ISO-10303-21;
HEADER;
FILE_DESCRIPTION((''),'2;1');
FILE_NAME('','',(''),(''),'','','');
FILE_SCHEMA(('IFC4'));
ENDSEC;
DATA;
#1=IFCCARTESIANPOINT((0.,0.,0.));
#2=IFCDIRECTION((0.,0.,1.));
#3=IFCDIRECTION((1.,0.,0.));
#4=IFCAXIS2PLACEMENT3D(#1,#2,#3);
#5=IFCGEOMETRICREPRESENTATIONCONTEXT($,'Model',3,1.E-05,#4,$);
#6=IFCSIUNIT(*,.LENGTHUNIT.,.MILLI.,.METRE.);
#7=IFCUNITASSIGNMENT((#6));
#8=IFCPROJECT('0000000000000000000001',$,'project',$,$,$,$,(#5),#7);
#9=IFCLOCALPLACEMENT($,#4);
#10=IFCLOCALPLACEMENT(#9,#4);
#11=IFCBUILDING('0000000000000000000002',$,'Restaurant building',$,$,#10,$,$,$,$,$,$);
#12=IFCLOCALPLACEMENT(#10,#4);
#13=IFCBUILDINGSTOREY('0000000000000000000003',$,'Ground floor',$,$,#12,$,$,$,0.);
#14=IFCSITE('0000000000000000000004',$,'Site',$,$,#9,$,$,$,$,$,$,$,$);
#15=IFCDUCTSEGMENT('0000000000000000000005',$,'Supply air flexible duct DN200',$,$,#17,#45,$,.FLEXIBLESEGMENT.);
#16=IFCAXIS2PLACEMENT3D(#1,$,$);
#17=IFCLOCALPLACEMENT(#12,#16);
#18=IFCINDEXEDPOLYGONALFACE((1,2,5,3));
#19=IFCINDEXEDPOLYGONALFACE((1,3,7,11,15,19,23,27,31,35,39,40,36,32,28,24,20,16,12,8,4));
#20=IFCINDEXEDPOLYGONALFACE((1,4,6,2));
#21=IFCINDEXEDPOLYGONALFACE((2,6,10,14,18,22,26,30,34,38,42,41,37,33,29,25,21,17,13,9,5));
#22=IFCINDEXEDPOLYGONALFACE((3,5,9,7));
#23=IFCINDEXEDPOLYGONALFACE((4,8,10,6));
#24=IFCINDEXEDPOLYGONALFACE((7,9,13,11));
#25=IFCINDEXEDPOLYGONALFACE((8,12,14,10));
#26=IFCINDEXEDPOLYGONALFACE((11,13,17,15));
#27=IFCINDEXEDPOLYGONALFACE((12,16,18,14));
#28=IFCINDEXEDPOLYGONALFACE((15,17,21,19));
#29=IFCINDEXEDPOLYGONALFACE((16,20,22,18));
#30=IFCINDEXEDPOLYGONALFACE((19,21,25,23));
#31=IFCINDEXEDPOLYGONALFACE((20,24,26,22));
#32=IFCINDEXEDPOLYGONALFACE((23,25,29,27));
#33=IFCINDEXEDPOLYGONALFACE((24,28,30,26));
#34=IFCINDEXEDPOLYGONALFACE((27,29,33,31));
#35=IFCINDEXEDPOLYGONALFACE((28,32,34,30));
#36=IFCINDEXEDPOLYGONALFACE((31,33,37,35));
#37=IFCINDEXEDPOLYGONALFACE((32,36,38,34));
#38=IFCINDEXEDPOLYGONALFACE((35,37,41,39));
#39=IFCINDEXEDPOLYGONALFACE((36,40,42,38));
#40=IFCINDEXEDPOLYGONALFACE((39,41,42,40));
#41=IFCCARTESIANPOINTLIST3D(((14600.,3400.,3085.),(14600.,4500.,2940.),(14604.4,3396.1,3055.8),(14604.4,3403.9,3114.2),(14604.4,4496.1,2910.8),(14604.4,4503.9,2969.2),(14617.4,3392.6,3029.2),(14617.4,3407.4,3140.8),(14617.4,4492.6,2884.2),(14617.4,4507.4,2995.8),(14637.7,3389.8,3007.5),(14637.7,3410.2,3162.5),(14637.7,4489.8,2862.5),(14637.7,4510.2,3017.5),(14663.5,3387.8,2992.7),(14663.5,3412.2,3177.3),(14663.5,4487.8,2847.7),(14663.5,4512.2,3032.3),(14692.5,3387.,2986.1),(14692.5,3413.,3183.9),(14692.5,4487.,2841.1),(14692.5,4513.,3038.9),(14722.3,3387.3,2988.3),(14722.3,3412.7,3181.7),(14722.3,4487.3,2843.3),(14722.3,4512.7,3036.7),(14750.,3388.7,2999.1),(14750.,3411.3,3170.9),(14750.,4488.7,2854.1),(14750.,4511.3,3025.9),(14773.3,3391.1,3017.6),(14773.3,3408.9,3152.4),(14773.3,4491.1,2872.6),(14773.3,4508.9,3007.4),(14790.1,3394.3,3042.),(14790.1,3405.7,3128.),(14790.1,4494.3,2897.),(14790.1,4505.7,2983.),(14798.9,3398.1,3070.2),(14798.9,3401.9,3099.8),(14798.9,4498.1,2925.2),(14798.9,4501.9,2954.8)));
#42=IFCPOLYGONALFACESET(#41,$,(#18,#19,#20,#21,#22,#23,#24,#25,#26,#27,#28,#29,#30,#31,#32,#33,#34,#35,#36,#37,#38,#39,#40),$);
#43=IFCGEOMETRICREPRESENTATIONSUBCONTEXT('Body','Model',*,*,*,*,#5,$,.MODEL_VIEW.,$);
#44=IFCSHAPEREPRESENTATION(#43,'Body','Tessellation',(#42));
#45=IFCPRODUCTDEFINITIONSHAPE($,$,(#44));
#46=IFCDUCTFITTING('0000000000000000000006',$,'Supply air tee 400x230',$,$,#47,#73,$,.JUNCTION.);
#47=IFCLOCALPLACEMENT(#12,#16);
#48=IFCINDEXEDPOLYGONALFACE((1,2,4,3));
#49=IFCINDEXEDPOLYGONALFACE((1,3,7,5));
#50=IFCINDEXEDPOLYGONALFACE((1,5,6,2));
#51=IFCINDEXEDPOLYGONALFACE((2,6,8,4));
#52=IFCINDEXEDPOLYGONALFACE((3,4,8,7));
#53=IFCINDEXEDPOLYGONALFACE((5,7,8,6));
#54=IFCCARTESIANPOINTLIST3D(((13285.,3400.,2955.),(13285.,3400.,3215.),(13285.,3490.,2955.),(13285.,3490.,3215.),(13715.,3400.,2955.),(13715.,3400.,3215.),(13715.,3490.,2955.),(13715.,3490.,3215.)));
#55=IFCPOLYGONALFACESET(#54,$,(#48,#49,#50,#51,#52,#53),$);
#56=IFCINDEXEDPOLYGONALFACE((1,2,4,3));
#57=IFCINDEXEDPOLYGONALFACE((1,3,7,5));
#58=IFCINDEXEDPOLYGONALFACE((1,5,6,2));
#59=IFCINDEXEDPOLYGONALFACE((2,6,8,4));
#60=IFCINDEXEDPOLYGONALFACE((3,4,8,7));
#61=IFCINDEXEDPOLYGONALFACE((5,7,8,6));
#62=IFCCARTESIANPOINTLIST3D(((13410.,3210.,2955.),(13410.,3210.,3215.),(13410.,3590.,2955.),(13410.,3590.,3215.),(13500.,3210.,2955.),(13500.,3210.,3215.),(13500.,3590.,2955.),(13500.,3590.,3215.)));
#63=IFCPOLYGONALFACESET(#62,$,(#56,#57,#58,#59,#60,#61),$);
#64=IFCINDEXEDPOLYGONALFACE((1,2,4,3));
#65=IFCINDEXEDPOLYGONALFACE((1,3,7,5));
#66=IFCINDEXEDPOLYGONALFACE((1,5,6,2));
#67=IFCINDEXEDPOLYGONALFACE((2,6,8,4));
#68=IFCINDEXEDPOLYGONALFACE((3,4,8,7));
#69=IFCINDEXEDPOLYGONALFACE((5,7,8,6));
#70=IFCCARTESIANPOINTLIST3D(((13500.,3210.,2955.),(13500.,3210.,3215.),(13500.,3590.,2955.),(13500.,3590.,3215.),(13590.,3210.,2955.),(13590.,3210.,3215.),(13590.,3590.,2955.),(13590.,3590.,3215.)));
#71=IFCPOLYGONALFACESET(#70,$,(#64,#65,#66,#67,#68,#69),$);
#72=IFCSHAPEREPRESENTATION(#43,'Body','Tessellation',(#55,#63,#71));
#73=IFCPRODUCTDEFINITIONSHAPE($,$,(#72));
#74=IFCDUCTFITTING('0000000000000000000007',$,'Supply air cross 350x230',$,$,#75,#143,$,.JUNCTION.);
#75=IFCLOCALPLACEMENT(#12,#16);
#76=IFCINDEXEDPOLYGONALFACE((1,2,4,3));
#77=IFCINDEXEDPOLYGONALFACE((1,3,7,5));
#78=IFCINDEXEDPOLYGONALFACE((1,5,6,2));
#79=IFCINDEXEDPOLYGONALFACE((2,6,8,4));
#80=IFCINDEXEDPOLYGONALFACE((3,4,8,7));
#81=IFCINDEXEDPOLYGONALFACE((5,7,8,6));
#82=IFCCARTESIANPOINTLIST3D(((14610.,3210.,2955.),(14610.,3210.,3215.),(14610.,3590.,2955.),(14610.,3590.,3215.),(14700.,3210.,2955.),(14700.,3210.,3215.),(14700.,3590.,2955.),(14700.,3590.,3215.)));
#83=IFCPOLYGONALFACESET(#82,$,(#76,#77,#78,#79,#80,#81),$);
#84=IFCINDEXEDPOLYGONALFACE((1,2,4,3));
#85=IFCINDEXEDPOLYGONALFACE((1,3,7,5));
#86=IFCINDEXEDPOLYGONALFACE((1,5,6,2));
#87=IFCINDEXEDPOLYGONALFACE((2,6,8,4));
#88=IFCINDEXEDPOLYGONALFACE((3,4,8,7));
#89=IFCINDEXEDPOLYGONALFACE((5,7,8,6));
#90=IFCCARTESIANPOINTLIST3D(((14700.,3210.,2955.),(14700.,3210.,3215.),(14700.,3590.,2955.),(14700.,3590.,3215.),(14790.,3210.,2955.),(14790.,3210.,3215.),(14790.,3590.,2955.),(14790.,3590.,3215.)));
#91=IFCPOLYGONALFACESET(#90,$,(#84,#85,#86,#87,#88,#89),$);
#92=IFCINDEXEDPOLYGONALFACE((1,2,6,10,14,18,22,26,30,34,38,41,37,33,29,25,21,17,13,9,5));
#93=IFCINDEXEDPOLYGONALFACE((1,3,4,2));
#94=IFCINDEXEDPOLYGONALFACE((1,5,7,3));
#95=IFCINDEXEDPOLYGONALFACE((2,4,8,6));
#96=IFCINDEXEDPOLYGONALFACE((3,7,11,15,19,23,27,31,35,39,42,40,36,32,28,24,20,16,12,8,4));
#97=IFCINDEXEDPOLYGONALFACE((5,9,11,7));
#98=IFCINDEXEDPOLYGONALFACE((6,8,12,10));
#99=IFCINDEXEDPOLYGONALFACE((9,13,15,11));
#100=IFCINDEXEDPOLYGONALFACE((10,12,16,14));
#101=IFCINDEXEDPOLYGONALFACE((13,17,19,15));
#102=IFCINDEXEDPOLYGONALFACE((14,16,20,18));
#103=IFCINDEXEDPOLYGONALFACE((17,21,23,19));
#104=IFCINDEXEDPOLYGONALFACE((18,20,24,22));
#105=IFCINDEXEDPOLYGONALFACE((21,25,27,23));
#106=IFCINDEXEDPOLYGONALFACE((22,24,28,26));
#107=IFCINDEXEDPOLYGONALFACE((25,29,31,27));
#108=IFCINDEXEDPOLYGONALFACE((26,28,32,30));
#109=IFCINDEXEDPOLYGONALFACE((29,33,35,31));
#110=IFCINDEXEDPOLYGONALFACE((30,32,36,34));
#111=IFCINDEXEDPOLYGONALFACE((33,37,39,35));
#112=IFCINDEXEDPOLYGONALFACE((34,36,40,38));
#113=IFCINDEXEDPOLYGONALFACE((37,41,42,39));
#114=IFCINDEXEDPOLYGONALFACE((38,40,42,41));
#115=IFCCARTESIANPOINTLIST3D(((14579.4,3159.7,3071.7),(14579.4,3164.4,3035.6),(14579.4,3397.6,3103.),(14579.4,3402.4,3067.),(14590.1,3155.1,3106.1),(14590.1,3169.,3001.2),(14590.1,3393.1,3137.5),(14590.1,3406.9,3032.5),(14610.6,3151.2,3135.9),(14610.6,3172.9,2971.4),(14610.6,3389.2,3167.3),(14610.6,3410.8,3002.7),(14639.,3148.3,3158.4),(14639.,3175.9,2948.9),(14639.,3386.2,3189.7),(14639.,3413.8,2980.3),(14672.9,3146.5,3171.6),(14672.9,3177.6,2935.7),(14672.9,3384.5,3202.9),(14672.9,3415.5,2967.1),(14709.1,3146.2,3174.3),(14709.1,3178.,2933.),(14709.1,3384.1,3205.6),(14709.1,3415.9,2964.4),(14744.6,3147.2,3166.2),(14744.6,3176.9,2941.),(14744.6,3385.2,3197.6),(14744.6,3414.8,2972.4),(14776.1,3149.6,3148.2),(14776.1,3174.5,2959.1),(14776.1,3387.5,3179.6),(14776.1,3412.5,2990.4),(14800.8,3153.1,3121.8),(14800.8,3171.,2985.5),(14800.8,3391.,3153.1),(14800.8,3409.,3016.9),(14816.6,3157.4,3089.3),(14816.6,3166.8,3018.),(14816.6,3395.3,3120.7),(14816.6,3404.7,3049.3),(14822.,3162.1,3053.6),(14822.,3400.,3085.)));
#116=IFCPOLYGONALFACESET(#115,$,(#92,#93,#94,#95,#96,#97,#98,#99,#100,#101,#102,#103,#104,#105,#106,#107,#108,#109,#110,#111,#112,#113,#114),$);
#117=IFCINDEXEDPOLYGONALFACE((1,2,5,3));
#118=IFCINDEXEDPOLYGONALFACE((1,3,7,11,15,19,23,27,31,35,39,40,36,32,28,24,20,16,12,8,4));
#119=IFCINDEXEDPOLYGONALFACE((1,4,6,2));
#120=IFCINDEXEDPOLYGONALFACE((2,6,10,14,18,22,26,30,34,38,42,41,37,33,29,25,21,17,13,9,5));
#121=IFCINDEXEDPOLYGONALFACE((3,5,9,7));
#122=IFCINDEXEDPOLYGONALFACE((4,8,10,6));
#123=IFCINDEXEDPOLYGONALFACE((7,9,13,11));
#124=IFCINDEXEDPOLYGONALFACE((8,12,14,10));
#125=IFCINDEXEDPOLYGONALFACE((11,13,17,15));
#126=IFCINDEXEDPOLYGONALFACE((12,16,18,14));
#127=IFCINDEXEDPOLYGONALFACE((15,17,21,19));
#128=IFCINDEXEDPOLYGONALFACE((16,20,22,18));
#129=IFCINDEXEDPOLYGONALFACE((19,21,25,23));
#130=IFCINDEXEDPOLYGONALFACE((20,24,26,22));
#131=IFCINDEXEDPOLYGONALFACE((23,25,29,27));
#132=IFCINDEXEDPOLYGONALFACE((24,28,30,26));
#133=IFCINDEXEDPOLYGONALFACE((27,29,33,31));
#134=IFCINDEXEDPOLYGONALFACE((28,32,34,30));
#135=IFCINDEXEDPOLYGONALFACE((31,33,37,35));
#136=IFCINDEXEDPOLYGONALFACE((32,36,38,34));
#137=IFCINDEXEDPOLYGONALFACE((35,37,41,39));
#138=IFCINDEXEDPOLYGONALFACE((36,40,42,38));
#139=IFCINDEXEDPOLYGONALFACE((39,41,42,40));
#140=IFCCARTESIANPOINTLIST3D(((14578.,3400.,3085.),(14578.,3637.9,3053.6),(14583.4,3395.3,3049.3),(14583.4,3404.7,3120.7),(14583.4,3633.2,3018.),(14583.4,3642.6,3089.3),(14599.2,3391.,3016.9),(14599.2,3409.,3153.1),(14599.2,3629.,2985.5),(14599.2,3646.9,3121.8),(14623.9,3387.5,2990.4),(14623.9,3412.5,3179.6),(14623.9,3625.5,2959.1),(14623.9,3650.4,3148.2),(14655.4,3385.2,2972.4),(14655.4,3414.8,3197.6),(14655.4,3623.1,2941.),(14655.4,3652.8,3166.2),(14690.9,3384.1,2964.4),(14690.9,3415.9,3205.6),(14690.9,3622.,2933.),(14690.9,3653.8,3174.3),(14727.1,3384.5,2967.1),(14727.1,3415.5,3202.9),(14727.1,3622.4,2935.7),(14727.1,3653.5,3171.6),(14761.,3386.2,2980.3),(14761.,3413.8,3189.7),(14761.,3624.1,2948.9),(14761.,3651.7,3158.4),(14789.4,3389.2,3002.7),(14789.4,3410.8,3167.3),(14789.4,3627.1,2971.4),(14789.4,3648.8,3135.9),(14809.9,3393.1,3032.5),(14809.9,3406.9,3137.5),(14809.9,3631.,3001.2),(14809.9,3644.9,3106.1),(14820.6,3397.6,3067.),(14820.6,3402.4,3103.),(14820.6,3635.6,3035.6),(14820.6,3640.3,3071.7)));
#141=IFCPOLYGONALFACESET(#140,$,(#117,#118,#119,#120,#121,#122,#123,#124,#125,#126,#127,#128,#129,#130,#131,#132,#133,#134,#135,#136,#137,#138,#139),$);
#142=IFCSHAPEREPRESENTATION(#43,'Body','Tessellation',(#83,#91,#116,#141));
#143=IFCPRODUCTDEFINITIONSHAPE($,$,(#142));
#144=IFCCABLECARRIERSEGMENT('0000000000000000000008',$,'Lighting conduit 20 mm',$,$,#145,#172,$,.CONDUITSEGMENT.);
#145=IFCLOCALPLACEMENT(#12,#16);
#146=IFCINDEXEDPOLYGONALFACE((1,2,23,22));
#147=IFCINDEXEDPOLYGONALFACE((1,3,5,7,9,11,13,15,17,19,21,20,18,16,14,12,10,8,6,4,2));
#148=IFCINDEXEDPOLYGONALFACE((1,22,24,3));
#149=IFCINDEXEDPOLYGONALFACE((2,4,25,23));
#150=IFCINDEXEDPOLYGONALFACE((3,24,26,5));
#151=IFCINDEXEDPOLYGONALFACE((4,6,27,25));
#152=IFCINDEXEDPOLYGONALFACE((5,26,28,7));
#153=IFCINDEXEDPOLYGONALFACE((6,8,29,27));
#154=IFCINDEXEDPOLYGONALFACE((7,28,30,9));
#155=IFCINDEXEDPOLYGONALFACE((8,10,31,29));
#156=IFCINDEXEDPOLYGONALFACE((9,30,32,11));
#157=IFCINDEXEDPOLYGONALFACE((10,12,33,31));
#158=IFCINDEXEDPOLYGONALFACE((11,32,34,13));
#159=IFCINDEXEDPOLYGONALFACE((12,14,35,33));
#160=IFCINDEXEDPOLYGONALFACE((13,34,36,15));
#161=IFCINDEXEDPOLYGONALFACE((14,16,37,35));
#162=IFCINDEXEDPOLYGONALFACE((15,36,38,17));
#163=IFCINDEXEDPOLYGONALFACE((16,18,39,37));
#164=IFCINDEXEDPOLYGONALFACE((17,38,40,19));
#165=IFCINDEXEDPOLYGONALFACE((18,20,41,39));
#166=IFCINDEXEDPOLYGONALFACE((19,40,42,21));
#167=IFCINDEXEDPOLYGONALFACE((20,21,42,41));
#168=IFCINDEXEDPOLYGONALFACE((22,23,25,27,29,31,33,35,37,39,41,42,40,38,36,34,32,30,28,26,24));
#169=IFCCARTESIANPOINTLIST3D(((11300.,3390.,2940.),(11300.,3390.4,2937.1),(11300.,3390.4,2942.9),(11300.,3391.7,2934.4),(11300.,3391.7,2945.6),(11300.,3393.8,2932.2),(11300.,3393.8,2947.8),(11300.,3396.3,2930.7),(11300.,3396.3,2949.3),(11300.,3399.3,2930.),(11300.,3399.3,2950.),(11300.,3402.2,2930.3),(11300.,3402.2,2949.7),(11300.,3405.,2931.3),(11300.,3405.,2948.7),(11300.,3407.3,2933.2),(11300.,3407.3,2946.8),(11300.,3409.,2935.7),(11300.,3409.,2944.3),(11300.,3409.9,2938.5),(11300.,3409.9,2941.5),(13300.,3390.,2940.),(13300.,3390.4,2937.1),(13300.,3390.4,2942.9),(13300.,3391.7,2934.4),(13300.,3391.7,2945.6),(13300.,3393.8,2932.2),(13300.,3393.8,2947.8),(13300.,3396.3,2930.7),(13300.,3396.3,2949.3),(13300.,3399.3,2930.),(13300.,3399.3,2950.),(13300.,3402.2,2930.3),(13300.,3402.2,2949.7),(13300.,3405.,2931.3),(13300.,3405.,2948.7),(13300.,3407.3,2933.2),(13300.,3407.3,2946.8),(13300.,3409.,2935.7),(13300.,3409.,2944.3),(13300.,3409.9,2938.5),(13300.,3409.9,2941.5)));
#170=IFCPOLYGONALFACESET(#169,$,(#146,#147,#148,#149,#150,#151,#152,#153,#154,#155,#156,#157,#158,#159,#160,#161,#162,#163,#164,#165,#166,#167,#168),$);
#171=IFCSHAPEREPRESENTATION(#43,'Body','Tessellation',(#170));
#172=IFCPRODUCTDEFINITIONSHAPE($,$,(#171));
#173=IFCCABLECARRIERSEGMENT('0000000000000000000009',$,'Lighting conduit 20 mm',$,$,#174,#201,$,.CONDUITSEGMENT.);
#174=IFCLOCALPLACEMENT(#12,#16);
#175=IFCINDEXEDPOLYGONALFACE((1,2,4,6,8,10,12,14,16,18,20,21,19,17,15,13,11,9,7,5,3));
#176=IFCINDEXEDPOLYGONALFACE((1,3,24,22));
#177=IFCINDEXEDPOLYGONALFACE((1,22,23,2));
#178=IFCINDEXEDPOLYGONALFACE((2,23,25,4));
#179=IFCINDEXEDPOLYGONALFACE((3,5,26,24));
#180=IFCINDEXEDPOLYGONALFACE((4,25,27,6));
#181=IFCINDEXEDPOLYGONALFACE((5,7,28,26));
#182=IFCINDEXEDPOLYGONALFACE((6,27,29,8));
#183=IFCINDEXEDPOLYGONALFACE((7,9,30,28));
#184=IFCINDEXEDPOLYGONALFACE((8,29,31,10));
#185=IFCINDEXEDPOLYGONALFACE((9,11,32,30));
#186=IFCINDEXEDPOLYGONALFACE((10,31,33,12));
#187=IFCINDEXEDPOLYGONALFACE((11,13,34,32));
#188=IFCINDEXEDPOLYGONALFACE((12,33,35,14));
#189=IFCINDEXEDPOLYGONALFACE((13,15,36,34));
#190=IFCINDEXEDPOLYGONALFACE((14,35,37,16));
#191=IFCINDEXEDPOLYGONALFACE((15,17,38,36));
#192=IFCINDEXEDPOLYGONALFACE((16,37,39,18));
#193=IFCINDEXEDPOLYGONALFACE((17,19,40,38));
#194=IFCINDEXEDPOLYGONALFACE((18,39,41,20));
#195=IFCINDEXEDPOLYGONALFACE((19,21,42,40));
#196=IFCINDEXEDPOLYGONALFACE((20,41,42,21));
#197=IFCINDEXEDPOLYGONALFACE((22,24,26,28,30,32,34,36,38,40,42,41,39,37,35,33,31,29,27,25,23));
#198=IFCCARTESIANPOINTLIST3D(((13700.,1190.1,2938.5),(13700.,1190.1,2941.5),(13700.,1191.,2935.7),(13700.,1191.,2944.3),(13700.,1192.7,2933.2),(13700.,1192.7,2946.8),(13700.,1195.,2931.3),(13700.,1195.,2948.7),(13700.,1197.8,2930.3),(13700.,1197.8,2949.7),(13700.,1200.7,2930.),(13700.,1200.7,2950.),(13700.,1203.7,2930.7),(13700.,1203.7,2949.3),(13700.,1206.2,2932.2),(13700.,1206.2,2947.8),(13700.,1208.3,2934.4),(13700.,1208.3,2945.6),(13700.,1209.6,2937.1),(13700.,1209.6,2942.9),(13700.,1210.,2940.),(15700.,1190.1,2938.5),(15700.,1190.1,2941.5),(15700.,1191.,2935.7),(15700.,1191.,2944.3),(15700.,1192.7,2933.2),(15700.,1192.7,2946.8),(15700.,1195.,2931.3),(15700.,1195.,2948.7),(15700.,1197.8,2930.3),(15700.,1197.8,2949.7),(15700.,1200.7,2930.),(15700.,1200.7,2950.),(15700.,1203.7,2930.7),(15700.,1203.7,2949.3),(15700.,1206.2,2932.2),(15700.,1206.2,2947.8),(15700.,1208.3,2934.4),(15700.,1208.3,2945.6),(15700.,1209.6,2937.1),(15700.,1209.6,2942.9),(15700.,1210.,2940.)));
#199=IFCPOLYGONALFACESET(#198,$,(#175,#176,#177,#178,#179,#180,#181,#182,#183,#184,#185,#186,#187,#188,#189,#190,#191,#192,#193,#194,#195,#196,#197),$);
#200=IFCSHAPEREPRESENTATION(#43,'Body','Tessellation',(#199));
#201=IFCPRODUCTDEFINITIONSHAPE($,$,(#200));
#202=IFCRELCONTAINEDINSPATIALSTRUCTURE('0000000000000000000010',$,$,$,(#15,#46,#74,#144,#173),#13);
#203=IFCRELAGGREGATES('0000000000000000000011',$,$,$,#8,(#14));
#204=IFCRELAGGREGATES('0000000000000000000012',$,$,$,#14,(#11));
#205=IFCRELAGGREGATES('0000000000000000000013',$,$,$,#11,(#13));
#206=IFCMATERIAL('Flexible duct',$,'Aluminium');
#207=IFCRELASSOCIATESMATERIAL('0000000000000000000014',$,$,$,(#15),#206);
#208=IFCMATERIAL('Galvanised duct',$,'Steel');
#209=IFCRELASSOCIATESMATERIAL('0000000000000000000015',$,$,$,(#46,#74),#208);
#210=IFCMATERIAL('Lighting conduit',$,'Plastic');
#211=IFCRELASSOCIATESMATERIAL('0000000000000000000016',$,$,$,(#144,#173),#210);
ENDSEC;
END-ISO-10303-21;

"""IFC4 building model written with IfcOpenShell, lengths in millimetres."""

from ifc_helpers import new_model, si_unit, frame, origin_with_axes, origin_2d, place, context, subcontext, project, spatial, rectangle, circle, extrude, material, element, save


model = new_model("IFC4")

# Units and contexts
model_context = context("Model", 3, precision=1e-05, world=origin_with_axes())
body_context = subcontext(model_context, "Body", "Model", "MODEL_VIEW")
ifc_project = project(units=[si_unit("LENGTHUNIT", "METRE", prefix="MILLI")], contexts=[model_context])

# Site, building, storey
site_placement = place(None, origin_with_axes())
site = spatial("IfcSite", under=ifc_project, at=site_placement, Name="Site")
building_placement = place(site_placement, origin_with_axes())
building = spatial("IfcBuilding", under=site, at=building_placement, Name="Restaurant building")
storey_placement = place(building_placement, origin_with_axes())
storey = spatial("IfcBuildingStorey", under=building, at=storey_placement, Name="Ground floor", Elevation=0.0)

# Duct segment
ifc_material_1 = material(Name="Galvanised duct", Category="Steel")
ifc_material_2 = material(Name="Flexible duct", Category="Aluminium")
duct_segment_1_placement = place(storey_placement, frame((14700.0, 3400.0, 3085.0)))
element("IfcDuctSegment", 1, at=duct_segment_1_placement, inside=storey, material=ifc_material_2, Name="Supply air flexible duct DN200", PredefinedType="FLEXIBLESEGMENT", context=body_context, shape_type="SweptSolid", body=[
    extrude(circle(Radius=100.0, at=origin_2d()), frame((0.0, 0.0, 0.0), z_axis=(0.0, 0.991424, -0.130688), x_axis=(-1.0, 0.0, 0.0)), (0.0, 0.0, 1.0), 1109.5),
])

# Duct fittings
duct_fitting_1_placement = place(storey_placement, frame((13500.0, 3400.0, 3085.0)))
element("IfcDuctFitting", 2, at=duct_fitting_1_placement, inside=storey, material=ifc_material_1, Name="Supply air tee 400x230", PredefinedType="JUNCTION", context=body_context, shape_type="SweptSolid", body=[
    extrude(rectangle(XDim=430.0, YDim=260.0, at=origin_2d()), frame((0.0, 0.0, 0.0), z_axis=(0.0, 1.0, 0.0), x_axis=(-1.0, 0.0, 0.0)), (0.0, 0.0, 1.0), 90.0),
    extrude(rectangle(XDim=380.0, YDim=260.0, at=origin_2d()), frame((0.0, 0.0, 0.0), z_axis=(-1.0, 0.0, 0.0), x_axis=(0.0, -1.0, 0.0)), (0.0, 0.0, 1.0), 90.0),
    extrude(rectangle(XDim=380.0, YDim=260.0, at=origin_2d()), frame((0.0, 0.0, 0.0), z_axis=(1.0, 0.0, 0.0), x_axis=(0.0, 1.0, 0.0)), (0.0, 0.0, 1.0), 90.0),
])
duct_fitting_2_placement = place(storey_placement, frame((14700.0, 3400.0, 3085.0)))
element("IfcDuctFitting", 3, at=duct_fitting_2_placement, inside=storey, material=ifc_material_1, Name="Supply air cross 350x230", PredefinedType="JUNCTION", context=body_context, shape_type="SweptSolid", body=[
    extrude(rectangle(XDim=380.0, YDim=260.0, at=origin_2d()), frame((0.0, 0.0, 0.0), z_axis=(-1.0, 0.0, 0.0), x_axis=(0.0, -1.0, 0.0)), (0.0, 0.0, 1.0), 90.0),
    extrude(rectangle(XDim=380.0, YDim=260.0, at=origin_2d()), frame((0.0, 0.0, 0.0), z_axis=(1.0, 0.0, 0.0), x_axis=(0.0, 1.0, 0.0)), (0.0, 0.0, 1.0), 90.0),
    extrude(circle(Radius=122.0, at=origin_2d()), frame((0.0, 0.0, 0.0), z_axis=(0.0, -0.991424, -0.130688), x_axis=(1.0, 0.0, 0.0)), (0.0, 0.0, 1.0), 240.0),
    extrude(circle(Radius=122.0, at=origin_2d()), frame((0.0, 0.0, 0.0), z_axis=(0.0, 0.991424, -0.130688), x_axis=(-1.0, 0.0, 0.0)), (0.0, 0.0, 1.0), 240.0),
])

# Cable carrier segments
ifc_material_3 = material(Name="Lighting conduit", Category="Plastic")
cable_carrier_segment_1_placement = place(storey_placement, frame((13300.0, 3400.0, 2940.0)))
element("IfcCableCarrierSegment", 4, at=cable_carrier_segment_1_placement, inside=storey, material=ifc_material_3, Name="Lighting conduit 20 mm", PredefinedType="CONDUITSEGMENT", context=body_context, shape_type="SweptSolid", body=[
    extrude(circle(Radius=10.0, at=origin_2d()), frame((0.0, 0.0, 0.0), z_axis=(-1.0, 0.0, 0.0), x_axis=(0.0, -1.0, 0.0)), (0.0, 0.0, 1.0), 2000.0),
])
cable_carrier_segment_2_placement = place(storey_placement, frame((13700.0, 1200.0, 2940.0)))
element("IfcCableCarrierSegment", 5, at=cable_carrier_segment_2_placement, inside=storey, material=ifc_material_3, Name="Lighting conduit 20 mm", PredefinedType="CONDUITSEGMENT", context=body_context, shape_type="SweptSolid", body=[
    extrude(circle(Radius=10.0, at=origin_2d()), frame((0.0, 0.0, 0.0), z_axis=(1.0, 0.0, 0.0), x_axis=(0.0, 1.0, 0.0)), (0.0, 0.0, 1.0), 2000.0),
])

save(model, "model.ifc")
